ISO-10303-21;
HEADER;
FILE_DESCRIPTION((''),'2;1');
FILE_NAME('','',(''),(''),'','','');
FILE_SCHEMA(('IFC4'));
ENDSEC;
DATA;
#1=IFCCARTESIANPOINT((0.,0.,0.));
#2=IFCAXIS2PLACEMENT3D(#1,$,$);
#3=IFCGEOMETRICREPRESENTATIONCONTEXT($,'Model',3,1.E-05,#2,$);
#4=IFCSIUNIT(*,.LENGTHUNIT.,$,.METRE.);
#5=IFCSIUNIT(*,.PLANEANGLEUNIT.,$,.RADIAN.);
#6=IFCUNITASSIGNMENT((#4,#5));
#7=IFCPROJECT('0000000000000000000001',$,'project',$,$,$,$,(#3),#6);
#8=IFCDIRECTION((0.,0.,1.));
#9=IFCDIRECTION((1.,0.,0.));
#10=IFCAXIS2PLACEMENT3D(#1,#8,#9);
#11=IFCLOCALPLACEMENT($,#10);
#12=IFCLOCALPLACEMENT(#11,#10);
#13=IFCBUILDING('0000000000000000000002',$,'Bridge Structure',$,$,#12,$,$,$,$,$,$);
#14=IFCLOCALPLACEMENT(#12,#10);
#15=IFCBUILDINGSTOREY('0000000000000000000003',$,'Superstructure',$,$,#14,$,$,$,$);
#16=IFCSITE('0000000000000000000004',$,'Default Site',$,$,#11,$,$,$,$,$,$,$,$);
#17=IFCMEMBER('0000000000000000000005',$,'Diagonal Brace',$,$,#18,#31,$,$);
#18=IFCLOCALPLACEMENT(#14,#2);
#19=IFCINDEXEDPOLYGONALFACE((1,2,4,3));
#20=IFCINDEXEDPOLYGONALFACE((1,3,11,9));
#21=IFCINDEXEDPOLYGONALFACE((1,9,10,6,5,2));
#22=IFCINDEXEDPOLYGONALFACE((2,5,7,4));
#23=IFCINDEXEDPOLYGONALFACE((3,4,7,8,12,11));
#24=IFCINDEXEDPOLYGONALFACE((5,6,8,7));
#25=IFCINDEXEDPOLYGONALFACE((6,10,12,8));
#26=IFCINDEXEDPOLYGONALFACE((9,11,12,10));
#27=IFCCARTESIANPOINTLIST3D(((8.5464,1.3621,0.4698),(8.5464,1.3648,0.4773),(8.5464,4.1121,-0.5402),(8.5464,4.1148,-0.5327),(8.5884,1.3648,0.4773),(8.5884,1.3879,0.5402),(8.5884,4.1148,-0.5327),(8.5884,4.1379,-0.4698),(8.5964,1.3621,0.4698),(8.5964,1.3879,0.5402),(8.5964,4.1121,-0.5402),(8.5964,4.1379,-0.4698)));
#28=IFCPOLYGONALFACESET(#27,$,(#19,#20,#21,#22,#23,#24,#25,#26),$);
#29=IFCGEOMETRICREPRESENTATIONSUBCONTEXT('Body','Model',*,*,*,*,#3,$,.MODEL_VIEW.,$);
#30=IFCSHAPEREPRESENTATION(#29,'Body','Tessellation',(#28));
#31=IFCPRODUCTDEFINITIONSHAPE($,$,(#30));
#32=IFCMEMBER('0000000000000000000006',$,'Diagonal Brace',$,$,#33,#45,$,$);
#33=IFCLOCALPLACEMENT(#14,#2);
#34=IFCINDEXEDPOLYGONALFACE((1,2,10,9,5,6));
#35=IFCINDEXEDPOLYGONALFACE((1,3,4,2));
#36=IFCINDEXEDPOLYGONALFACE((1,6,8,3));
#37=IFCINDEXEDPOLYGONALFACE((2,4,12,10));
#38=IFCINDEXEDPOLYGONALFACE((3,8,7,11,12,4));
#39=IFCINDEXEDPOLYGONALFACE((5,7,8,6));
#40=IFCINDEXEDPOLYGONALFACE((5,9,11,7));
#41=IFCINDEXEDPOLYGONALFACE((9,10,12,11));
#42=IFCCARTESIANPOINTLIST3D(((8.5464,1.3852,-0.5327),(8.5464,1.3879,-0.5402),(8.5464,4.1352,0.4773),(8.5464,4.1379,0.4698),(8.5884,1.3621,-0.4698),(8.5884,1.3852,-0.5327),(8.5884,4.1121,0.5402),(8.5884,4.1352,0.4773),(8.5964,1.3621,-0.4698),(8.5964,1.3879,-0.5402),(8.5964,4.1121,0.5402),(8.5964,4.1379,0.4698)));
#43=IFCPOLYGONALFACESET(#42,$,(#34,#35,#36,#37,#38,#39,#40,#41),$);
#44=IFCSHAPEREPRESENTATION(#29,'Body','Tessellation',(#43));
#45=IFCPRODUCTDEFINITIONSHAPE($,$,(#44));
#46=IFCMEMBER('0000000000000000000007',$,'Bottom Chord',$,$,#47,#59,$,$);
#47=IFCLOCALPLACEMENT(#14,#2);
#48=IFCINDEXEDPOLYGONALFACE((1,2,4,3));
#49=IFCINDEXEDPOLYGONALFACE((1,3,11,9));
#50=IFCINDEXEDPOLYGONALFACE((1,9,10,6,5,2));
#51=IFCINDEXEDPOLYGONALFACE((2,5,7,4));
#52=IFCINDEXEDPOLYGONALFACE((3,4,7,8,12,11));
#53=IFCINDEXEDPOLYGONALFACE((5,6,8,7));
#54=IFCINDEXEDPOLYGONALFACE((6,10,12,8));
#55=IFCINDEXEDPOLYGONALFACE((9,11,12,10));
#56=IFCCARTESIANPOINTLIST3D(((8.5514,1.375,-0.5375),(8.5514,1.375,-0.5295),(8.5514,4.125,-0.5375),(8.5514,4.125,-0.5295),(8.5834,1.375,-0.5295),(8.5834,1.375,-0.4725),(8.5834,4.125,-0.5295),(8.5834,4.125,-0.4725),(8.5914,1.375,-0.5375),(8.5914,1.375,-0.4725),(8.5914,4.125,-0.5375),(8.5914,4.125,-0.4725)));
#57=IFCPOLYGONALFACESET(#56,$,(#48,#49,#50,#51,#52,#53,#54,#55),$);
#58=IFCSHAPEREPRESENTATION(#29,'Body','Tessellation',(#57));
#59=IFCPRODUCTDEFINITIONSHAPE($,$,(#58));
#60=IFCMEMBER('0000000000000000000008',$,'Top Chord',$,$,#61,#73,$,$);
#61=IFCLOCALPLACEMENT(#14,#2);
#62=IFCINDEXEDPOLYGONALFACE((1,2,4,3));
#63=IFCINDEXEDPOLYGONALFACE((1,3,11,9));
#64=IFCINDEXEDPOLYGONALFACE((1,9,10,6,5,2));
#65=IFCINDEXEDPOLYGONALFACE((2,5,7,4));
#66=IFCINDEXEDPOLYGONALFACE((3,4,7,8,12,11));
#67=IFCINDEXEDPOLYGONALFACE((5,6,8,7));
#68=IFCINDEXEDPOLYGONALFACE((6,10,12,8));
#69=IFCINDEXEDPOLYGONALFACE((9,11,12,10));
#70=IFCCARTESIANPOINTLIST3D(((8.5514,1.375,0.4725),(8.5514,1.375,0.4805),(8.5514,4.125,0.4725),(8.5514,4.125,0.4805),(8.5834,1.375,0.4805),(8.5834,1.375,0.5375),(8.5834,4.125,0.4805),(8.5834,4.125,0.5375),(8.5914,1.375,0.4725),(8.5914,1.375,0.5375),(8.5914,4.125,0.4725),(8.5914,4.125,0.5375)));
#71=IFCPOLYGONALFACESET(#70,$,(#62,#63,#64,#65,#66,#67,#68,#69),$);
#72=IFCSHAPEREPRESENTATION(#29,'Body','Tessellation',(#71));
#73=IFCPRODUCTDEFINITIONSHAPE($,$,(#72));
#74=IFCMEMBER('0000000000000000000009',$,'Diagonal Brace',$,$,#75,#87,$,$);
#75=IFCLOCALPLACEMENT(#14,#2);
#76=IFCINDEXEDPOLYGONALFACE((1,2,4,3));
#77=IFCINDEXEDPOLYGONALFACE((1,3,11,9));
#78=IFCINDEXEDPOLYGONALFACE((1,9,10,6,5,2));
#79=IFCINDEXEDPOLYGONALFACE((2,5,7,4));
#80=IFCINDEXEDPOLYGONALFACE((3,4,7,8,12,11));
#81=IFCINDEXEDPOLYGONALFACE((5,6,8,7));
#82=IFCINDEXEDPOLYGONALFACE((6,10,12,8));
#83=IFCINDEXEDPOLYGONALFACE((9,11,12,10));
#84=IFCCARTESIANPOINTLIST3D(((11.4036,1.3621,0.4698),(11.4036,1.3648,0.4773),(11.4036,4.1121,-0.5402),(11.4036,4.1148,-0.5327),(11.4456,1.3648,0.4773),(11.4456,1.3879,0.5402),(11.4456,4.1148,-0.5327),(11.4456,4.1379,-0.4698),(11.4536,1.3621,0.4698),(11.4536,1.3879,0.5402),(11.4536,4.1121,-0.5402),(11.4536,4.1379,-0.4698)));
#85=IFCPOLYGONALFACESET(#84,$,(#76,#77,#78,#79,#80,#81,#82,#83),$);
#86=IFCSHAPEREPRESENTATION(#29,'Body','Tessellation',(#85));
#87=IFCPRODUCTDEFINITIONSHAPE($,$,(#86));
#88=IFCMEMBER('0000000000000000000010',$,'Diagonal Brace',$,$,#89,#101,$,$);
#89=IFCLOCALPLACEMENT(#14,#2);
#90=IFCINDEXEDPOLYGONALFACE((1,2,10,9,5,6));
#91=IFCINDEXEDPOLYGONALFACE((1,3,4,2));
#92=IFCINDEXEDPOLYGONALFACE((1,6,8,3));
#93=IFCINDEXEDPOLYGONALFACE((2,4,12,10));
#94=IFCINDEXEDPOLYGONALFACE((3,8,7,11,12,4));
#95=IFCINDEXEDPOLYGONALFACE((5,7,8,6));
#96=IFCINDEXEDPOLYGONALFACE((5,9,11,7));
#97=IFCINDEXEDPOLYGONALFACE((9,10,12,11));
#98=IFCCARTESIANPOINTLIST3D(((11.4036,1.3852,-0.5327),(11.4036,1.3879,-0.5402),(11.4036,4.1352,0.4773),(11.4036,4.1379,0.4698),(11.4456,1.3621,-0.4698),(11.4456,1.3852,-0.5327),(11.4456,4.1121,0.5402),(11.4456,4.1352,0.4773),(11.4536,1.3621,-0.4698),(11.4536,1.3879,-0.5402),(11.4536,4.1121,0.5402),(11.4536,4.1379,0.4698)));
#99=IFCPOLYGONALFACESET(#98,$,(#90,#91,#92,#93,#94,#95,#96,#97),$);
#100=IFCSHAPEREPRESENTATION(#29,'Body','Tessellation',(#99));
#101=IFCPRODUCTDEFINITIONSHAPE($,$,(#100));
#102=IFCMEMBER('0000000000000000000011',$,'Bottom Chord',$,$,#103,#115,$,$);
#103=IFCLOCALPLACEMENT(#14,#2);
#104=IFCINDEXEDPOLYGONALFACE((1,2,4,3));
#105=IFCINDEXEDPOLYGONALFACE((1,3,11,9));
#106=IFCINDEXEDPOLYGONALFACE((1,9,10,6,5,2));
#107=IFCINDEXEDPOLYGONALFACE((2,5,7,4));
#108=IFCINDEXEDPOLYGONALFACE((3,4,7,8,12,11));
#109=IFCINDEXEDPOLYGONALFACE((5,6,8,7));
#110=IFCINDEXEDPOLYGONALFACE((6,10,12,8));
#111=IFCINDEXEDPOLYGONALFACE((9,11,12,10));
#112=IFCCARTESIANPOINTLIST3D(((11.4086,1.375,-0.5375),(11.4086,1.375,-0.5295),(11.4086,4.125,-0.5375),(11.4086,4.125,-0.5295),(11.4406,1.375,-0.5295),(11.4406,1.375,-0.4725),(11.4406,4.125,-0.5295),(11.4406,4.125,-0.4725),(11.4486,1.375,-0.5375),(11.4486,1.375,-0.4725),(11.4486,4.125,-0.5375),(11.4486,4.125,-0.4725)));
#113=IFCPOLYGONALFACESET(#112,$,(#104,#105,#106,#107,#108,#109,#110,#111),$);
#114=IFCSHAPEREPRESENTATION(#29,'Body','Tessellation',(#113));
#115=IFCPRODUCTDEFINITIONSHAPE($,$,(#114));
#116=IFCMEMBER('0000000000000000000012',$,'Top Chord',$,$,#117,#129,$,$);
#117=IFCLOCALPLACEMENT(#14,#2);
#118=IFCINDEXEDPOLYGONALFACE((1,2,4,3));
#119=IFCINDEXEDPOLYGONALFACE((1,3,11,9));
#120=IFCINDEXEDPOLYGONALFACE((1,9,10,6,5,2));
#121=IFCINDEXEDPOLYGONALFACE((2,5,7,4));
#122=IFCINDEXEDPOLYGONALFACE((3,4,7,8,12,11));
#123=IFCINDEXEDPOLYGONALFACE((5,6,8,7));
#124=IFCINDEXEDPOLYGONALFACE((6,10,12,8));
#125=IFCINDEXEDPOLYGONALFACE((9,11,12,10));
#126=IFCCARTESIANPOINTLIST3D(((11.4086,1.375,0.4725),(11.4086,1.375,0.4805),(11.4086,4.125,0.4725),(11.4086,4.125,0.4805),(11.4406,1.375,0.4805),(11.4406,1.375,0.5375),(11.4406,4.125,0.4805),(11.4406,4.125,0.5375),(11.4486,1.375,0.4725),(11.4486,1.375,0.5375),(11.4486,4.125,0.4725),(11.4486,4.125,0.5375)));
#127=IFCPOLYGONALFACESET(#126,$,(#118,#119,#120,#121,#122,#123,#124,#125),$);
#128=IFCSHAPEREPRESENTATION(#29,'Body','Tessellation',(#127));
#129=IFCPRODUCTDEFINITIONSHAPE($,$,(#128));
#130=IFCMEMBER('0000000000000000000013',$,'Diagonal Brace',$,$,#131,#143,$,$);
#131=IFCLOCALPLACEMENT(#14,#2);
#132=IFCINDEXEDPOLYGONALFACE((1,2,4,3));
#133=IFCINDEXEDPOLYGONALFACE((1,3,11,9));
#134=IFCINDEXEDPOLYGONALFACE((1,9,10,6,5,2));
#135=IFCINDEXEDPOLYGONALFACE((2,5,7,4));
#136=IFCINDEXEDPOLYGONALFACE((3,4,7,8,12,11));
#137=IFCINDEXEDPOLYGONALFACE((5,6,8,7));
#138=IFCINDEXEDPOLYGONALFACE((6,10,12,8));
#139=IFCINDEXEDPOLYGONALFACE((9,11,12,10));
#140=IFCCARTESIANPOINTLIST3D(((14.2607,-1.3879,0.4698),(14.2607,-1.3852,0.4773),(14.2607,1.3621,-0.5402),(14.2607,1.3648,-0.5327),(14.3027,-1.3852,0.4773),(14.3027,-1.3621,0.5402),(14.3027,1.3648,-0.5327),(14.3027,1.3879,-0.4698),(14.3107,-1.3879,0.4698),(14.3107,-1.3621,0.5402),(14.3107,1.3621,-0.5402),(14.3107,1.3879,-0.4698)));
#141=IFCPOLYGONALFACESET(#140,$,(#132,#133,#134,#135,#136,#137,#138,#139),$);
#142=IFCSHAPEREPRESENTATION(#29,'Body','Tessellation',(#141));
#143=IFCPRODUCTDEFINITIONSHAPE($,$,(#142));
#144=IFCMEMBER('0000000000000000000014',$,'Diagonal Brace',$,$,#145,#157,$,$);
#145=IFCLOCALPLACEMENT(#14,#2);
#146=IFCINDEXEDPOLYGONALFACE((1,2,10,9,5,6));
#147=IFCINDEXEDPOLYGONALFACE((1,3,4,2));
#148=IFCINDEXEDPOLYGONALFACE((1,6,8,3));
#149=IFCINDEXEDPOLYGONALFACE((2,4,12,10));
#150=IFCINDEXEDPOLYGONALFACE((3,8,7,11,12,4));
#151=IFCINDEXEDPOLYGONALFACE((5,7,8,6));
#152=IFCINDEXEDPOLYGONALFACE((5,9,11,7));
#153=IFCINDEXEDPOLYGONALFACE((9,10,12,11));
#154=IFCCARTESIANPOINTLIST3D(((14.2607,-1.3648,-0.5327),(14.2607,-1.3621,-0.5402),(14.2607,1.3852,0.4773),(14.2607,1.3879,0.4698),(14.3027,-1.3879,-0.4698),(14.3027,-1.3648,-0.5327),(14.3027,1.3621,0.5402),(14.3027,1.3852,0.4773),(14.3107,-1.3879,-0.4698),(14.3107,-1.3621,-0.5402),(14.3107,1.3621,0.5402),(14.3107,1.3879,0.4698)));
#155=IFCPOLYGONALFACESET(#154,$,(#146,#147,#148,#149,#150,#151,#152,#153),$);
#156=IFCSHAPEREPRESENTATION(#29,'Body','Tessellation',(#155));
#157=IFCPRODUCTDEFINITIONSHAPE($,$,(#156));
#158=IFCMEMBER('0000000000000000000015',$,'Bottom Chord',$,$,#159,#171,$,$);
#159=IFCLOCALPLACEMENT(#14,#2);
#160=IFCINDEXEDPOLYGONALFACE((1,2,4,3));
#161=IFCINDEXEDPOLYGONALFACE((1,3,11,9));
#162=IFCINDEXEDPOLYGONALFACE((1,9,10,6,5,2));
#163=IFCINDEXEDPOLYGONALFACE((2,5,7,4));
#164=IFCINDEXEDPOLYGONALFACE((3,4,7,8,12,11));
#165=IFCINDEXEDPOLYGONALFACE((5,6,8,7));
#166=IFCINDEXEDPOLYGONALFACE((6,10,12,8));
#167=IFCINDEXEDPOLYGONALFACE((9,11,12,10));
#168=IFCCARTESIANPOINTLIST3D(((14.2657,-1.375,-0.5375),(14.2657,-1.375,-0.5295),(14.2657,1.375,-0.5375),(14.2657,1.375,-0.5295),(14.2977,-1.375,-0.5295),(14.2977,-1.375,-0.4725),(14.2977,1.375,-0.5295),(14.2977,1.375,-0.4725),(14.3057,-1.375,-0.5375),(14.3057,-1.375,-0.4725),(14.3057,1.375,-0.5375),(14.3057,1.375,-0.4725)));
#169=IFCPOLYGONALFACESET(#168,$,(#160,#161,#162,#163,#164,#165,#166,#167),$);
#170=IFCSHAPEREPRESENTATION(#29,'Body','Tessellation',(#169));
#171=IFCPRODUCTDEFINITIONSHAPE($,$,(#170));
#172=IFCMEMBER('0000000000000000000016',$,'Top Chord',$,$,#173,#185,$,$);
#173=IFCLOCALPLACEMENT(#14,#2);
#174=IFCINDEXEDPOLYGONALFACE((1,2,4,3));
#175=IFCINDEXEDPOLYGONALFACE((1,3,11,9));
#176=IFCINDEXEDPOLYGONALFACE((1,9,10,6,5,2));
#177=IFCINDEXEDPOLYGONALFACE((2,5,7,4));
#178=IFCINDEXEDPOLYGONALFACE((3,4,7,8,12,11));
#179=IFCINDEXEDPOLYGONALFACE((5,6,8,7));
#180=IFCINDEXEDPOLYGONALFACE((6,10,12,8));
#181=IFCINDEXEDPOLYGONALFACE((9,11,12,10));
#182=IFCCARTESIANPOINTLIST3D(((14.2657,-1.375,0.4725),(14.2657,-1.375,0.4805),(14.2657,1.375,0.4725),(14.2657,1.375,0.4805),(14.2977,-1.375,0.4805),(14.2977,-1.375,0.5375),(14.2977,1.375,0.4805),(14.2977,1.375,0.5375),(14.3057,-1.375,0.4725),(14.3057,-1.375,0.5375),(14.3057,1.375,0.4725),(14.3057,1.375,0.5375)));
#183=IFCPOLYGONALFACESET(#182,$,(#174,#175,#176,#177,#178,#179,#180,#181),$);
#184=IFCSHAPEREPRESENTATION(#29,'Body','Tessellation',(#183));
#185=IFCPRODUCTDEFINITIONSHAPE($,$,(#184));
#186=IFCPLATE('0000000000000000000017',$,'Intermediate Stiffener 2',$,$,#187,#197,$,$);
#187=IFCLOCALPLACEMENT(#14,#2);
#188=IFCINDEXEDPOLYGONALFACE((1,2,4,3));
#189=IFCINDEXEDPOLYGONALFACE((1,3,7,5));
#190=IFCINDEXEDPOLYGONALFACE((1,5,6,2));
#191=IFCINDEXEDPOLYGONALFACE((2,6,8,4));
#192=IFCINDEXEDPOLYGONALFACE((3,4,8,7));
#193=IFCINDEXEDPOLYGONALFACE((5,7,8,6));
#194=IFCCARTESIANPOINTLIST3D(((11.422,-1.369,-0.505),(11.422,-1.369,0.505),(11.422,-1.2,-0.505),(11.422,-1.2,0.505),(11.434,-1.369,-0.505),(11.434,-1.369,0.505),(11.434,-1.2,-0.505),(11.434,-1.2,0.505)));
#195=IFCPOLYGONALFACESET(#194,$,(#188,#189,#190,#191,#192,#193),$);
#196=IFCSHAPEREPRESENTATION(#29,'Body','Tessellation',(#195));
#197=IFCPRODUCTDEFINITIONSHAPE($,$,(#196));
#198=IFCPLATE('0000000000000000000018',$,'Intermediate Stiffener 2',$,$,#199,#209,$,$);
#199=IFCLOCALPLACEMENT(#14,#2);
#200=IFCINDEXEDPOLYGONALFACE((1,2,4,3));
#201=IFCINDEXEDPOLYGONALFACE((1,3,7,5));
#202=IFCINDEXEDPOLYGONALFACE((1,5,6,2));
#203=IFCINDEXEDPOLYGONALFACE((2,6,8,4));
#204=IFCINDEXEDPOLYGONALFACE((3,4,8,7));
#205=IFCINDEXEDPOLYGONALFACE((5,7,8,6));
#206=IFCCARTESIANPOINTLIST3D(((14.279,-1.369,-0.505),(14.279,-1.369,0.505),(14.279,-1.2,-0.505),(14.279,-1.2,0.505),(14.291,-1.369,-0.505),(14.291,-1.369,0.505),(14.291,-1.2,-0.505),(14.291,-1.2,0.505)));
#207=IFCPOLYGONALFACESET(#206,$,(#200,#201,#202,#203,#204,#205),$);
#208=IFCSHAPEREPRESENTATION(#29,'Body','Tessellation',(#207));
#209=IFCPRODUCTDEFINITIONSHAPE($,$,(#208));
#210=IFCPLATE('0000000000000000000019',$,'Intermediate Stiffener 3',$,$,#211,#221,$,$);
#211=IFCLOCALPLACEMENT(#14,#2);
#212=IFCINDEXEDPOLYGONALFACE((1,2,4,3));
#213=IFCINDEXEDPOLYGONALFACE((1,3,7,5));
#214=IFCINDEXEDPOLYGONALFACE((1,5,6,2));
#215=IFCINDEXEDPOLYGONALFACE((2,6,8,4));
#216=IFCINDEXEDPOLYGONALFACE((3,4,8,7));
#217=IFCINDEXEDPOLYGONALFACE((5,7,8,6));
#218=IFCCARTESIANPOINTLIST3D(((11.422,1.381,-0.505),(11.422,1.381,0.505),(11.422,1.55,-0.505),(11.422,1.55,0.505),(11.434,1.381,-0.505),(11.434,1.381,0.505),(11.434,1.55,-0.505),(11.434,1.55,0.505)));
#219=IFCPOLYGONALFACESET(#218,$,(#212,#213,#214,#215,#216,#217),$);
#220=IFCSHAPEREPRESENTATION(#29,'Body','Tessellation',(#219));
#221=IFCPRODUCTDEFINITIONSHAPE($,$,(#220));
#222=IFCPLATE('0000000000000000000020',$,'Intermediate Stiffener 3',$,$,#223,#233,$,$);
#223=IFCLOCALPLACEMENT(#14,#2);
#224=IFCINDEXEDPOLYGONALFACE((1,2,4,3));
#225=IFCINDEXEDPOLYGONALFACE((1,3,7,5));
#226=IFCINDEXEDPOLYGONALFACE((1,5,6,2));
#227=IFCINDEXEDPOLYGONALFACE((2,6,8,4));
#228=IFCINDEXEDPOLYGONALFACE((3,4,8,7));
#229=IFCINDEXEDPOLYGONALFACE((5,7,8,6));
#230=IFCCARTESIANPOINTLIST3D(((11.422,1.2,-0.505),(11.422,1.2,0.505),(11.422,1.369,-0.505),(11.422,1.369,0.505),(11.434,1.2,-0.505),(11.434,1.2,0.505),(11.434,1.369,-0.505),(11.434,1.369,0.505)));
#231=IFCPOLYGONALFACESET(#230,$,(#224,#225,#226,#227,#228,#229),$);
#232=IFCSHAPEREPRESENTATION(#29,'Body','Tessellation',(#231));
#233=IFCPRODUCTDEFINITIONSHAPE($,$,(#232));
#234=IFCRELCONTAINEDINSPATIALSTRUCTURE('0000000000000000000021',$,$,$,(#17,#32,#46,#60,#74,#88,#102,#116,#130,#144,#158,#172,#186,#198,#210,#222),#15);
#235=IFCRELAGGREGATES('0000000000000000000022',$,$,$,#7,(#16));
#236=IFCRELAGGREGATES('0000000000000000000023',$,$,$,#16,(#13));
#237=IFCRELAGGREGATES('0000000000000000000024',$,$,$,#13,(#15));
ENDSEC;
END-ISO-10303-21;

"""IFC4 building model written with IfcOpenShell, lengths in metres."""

from ifc_helpers import new_model, si_unit, frame, origin, origin_with_axes, origin_2d_with_axis, place, context, subcontext, project, spatial, rectangle, l_section, extrude, element, save


model = new_model("IFC4")

# Units and contexts
model_context = context("Model", 3, precision=1e-05, world=origin())
body_context = subcontext(model_context, "Body", "Model", "MODEL_VIEW")
ifc_project = project(units=[si_unit("LENGTHUNIT", "METRE"), si_unit("PLANEANGLEUNIT", "RADIAN")], contexts=[model_context])

# Site, building, storey
site_placement = place(None, origin_with_axes())
site = spatial("IfcSite", under=ifc_project, at=site_placement, Name="Default Site")
building_placement = place(site_placement, origin_with_axes())
building = spatial("IfcBuilding", under=site, at=building_placement, Name="Bridge Structure")
storey_placement = place(building_placement, origin_with_axes())
storey = spatial("IfcBuildingStorey", under=building, at=storey_placement, Name="Superstructure")

# Members
for number, where, z_axis, x_axis, name in (
    (1, (8.5714, 1.375, 0.505), (0.0, 0.938692, -0.344756), (-1.0, 0.0, 0.0), "Diagonal Brace"),
    (2, (8.5714, 1.375, -0.505), (0.0, 0.938692, 0.344756), (-1.0, 0.0, 0.0), "Diagonal Brace"),
):
    element("IfcMember", number, at=place(storey_placement, frame(where, z_axis=z_axis, x_axis=x_axis)), inside=storey, Name=name, context=body_context, shape_type="SweptSolid", body=[
        extrude(l_section(Depth=0.075, Width=0.05, Thickness=0.008, at=origin_2d_with_axis()), origin_with_axes(), (0.0, 0.0, 1.0), 2.9296),
    ])
for number, where, z_axis, x_axis, name in (
    (3, (8.5714, 1.375, -0.505), (0.0, 1.0, 0.0), (-1.0, 0.0, 0.0), "Bottom Chord"),
    (4, (8.5714, 1.375, 0.505), (0.0, 1.0, 0.0), (-1.0, 0.0, 0.0), "Top Chord"),
):
    element("IfcMember", number, at=place(storey_placement, frame(where, z_axis=z_axis, x_axis=x_axis)), inside=storey, Name=name, context=body_context, shape_type="SweptSolid", body=[
        extrude(l_section(Depth=0.065, Width=0.04, Thickness=0.008, at=origin_2d_with_axis()), origin_with_axes(), (0.0, 0.0, 1.0), 2.75),
    ])
for number, where, z_axis, x_axis, name in (
    (5, (11.4286, 1.375, 0.505), (0.0, 0.938692, -0.344756), (-1.0, 0.0, 0.0), "Diagonal Brace"),
    (6, (11.4286, 1.375, -0.505), (0.0, 0.938692, 0.344756), (-1.0, 0.0, 0.0), "Diagonal Brace"),
):
    element("IfcMember", number, at=place(storey_placement, frame(where, z_axis=z_axis, x_axis=x_axis)), inside=storey, Name=name, context=body_context, shape_type="SweptSolid", body=[
        extrude(l_section(Depth=0.075, Width=0.05, Thickness=0.008, at=origin_2d_with_axis()), origin_with_axes(), (0.0, 0.0, 1.0), 2.9296),
    ])
for number, where, z_axis, x_axis, name in (
    (7, (11.4286, 1.375, -0.505), (0.0, 1.0, 0.0), (-1.0, 0.0, 0.0), "Bottom Chord"),
    (8, (11.4286, 1.375, 0.505), (0.0, 1.0, 0.0), (-1.0, 0.0, 0.0), "Top Chord"),
):
    element("IfcMember", number, at=place(storey_placement, frame(where, z_axis=z_axis, x_axis=x_axis)), inside=storey, Name=name, context=body_context, shape_type="SweptSolid", body=[
        extrude(l_section(Depth=0.065, Width=0.04, Thickness=0.008, at=origin_2d_with_axis()), origin_with_axes(), (0.0, 0.0, 1.0), 2.75),
    ])
for number, where, z_axis, x_axis, name in (
    (9, (14.2857, -1.375, 0.505), (0.0, 0.938692, -0.344756), (-1.0, 0.0, 0.0), "Diagonal Brace"),
    (10, (14.2857, -1.375, -0.505), (0.0, 0.938692, 0.344756), (-1.0, 0.0, 0.0), "Diagonal Brace"),
):
    element("IfcMember", number, at=place(storey_placement, frame(where, z_axis=z_axis, x_axis=x_axis)), inside=storey, Name=name, context=body_context, shape_type="SweptSolid", body=[
        extrude(l_section(Depth=0.075, Width=0.05, Thickness=0.008, at=origin_2d_with_axis()), origin_with_axes(), (0.0, 0.0, 1.0), 2.9296),
    ])
for number, where, z_axis, x_axis, name in (
    (11, (14.2857, -1.375, -0.505), (0.0, 1.0, 0.0), (-1.0, 0.0, 0.0), "Bottom Chord"),
    (12, (14.2857, -1.375, 0.505), (0.0, 1.0, 0.0), (-1.0, 0.0, 0.0), "Top Chord"),
):
    element("IfcMember", number, at=place(storey_placement, frame(where, z_axis=z_axis, x_axis=x_axis)), inside=storey, Name=name, context=body_context, shape_type="SweptSolid", body=[
        extrude(l_section(Depth=0.065, Width=0.04, Thickness=0.008, at=origin_2d_with_axis()), origin_with_axes(), (0.0, 0.0, 1.0), 2.75),
    ])

# Plates
for number, where, z_axis, x_axis, name in (
    (13, (11.428, -1.2845, -0.505), (0.0, 0.0, 1.0), (1.0, 0.0, 0.0), "Intermediate Stiffener 2"),
    (14, (14.285, -1.2845, -0.505), (0.0, 0.0, 1.0), (1.0, 0.0, 0.0), "Intermediate Stiffener 2"),
    (15, (11.428, 1.4655, -0.505), (0.0, 0.0, 1.0), (1.0, 0.0, 0.0), "Intermediate Stiffener 3"),
    (16, (11.428, 1.2845, -0.505), (0.0, 0.0, 1.0), (1.0, 0.0, 0.0), "Intermediate Stiffener 3"),
):
    element("IfcPlate", number, at=place(storey_placement, frame(where, z_axis=z_axis, x_axis=x_axis)), inside=storey, Name=name, context=body_context, shape_type="SweptSolid", body=[
        extrude(rectangle(XDim=0.012, YDim=0.169, at=origin_2d_with_axis()), origin_with_axes(), (0.0, 0.0, 1.0), 1.01),
    ])

save(model, "model.ifc")
